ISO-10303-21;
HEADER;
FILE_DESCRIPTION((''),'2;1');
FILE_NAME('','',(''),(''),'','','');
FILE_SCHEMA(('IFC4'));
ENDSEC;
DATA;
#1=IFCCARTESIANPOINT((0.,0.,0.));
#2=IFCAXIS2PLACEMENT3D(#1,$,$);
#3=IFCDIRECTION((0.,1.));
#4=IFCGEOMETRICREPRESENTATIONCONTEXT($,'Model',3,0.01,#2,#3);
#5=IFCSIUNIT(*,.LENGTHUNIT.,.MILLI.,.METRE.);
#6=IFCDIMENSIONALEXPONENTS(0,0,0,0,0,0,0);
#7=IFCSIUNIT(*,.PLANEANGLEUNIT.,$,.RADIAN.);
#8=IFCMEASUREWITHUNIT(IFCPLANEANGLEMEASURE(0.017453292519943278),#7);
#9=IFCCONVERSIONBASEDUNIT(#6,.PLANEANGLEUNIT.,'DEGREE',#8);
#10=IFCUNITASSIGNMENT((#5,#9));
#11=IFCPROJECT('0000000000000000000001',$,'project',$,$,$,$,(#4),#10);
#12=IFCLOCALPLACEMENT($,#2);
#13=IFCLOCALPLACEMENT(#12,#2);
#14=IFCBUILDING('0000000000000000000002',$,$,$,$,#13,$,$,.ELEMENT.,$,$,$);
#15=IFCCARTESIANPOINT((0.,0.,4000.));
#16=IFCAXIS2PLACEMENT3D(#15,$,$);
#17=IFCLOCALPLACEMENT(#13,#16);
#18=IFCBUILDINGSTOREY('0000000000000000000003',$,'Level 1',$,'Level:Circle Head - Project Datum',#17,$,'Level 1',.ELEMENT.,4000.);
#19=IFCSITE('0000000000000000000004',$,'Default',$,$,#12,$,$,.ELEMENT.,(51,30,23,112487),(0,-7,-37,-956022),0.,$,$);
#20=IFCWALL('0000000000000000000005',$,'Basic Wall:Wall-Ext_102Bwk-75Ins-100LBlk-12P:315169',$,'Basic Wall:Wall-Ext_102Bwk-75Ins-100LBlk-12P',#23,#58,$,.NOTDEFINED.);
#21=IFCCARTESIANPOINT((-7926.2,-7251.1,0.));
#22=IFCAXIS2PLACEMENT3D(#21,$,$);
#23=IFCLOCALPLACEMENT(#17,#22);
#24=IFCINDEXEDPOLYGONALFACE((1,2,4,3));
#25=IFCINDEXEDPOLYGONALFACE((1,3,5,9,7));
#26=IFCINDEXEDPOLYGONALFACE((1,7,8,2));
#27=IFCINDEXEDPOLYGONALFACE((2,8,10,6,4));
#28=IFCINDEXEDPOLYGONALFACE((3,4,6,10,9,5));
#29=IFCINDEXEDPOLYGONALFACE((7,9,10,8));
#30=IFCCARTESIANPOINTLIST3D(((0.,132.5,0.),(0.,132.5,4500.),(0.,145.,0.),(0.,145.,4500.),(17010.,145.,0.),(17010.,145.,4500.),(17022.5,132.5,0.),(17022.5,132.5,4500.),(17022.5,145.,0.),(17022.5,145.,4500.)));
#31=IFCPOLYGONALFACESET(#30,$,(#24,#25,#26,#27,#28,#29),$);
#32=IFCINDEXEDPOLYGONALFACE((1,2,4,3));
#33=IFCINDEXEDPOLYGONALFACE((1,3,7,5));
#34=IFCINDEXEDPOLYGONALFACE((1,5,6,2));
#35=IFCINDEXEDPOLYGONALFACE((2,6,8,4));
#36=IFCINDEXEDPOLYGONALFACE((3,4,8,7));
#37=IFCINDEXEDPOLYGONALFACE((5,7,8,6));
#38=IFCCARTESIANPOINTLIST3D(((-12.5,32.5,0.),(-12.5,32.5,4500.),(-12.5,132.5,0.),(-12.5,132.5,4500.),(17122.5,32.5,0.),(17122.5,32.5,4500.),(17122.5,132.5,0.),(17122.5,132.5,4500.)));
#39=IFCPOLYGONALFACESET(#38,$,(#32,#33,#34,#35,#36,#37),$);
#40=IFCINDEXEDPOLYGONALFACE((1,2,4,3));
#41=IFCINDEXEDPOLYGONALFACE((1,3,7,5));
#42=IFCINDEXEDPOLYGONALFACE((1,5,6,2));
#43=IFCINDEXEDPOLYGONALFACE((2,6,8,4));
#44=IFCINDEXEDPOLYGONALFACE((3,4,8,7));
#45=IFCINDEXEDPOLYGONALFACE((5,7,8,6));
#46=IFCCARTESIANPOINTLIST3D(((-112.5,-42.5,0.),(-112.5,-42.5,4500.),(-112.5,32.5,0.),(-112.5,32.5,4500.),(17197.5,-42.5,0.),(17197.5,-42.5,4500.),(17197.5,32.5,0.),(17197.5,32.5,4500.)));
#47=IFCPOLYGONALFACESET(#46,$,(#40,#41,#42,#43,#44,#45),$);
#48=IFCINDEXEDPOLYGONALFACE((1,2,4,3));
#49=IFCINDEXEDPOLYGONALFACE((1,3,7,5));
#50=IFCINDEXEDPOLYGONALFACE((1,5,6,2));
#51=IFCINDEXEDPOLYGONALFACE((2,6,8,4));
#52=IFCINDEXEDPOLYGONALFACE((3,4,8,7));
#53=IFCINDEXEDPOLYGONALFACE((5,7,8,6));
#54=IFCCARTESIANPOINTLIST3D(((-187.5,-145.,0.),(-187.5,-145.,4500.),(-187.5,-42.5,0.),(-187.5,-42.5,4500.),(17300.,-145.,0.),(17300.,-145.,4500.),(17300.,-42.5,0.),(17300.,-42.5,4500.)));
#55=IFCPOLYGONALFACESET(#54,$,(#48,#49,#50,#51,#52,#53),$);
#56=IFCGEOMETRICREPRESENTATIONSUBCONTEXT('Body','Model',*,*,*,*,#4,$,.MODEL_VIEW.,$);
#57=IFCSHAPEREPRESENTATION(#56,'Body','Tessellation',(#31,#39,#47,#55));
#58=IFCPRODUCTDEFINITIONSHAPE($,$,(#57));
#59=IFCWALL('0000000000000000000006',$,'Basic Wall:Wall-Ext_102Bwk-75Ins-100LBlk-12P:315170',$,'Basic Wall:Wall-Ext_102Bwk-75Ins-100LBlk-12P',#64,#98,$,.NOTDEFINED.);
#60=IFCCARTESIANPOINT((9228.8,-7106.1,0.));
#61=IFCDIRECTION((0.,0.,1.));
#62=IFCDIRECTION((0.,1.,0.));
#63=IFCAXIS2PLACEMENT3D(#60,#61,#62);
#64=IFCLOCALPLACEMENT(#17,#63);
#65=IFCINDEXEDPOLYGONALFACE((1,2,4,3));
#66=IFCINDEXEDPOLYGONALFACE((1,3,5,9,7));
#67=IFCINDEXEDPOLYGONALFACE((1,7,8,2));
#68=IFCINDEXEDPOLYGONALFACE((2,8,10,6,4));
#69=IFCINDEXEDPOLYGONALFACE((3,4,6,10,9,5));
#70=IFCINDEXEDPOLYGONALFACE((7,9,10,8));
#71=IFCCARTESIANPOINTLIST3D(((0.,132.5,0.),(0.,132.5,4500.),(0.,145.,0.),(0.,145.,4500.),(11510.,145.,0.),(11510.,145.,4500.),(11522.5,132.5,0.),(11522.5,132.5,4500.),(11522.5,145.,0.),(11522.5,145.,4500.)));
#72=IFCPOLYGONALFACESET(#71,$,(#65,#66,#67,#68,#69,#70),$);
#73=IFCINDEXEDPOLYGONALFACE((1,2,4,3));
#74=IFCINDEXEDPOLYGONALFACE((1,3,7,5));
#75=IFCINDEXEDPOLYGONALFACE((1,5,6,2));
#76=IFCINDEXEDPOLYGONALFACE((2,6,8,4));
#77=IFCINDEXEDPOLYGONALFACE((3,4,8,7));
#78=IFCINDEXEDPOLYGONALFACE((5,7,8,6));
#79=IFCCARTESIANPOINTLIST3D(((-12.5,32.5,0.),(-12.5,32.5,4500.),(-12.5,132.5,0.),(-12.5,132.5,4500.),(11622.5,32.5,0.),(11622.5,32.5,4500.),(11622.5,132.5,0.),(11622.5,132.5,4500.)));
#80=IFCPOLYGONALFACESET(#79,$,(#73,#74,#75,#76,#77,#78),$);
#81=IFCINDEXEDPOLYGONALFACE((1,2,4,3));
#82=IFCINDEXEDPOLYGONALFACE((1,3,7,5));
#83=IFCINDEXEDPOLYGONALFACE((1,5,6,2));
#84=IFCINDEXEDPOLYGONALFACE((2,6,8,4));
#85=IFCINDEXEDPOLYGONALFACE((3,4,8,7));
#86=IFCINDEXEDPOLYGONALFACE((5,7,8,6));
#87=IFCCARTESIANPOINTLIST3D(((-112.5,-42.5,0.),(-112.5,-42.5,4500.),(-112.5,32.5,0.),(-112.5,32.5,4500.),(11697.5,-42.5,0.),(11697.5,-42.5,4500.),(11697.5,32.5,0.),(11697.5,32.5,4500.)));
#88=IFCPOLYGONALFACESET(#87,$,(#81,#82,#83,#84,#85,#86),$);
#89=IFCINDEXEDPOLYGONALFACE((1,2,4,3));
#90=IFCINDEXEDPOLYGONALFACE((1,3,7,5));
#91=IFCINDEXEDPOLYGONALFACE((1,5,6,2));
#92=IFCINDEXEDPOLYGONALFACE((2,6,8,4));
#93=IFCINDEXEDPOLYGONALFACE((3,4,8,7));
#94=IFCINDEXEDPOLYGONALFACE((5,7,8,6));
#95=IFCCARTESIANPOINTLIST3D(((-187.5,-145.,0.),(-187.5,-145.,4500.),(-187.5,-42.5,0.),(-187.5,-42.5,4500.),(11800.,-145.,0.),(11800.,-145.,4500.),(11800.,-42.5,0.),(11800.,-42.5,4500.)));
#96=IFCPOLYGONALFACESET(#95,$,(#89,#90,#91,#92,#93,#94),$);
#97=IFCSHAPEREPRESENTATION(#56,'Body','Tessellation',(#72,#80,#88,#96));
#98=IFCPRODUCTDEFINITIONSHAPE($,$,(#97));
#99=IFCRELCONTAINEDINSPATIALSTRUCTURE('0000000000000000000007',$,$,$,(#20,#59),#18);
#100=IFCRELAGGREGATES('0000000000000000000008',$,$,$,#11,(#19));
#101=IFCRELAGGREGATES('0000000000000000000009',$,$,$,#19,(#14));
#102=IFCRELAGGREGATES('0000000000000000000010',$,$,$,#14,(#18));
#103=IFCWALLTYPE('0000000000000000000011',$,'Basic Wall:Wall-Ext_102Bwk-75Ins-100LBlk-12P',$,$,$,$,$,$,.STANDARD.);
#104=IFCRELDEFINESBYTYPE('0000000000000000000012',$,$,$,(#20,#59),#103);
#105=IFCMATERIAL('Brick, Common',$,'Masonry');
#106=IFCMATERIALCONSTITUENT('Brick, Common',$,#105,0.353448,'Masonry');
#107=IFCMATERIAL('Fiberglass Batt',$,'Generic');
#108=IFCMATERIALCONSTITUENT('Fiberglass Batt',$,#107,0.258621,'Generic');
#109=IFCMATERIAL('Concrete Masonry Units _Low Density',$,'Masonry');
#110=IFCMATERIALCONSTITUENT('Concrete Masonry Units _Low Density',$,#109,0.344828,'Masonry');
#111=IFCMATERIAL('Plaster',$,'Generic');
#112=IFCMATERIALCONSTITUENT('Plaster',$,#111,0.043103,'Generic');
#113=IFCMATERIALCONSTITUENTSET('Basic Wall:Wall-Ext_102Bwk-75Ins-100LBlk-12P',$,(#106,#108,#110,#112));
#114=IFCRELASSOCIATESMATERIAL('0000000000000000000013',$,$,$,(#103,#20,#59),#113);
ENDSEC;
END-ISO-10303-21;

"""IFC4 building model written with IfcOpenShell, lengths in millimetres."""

from ifc_helpers import new_model, entity, si_unit, converted_unit, direction, frame, origin, place, context, subcontext, project, spatial, indexed_curve, outline, extrude, material, constituent, constituent_set, type_object, element, save


model = new_model("IFC4")

# Units and contexts
model_context = context("Model", 3, precision=0.01, world=origin(), true_north=direction((0.0, 1.0)))
body_context = subcontext(model_context, "Body", "Model", "MODEL_VIEW")
ifc_project = project(units=[si_unit("LENGTHUNIT", "METRE", prefix="MILLI"), converted_unit("PLANEANGLEUNIT", "DEGREE", entity("IfcPlaneAngleMeasure", 0.017453292519943278), si_unit("PLANEANGLEUNIT", "RADIAN"), dimensions=[0, 0, 0, 0, 0, 0, 0])], contexts=[model_context])

# Site, building, storey
site_placement = place(None, origin())
site = spatial("IfcSite", under=ifc_project, at=site_placement, Name="Default", CompositionType="ELEMENT", RefLatitude=(51, 30, 23, 112487), RefLongitude=(0, -7, -37, -956022), RefElevation=0.0)
building_placement = place(site_placement, origin())
building = spatial("IfcBuilding", under=site, at=building_placement, CompositionType="ELEMENT")
storey_placement = place(building_placement, frame((0.0, 0.0, 4000.0)))
storey = spatial("IfcBuildingStorey", under=building, at=storey_placement, Name="Level 1", ObjectType="Level:Circle Head - Project Datum", LongName="Level 1", CompositionType="ELEMENT", Elevation=4000.0)

# Shared definitions
ifc_material_1 = material(Name="Plaster", Category="Generic")

# Walls
ifc_material_2 = material(Name="Brick, Common", Category="Masonry")
ifc_constituent_1 = constituent(ifc_material_2, Name="Brick, Common", Category="Masonry", fraction=0.353448)
ifc_material_3 = material(Name="Fiberglass Batt", Category="Generic")
ifc_constituent_2 = constituent(ifc_material_3, Name="Fiberglass Batt", Category="Generic", fraction=0.258621)
ifc_material_4 = material(Name="Concrete Masonry Units _Low Density", Category="Masonry")
ifc_constituent_3 = constituent(ifc_material_4, Name="Concrete Masonry Units _Low Density", Category="Masonry", fraction=0.344828)
ifc_constituent_4 = constituent(ifc_material_1, Name="Plaster", Category="Generic", fraction=0.043103)
ifc_constituent_set_1 = constituent_set(constituents=[ifc_constituent_1, ifc_constituent_2, ifc_constituent_3, ifc_constituent_4], Name="Basic Wall:Wall-Ext_102Bwk-75Ins-100LBlk-12P")
wall_type_1 = type_object("IfcWallType", Name="Basic Wall:Wall-Ext_102Bwk-75Ins-100LBlk-12P", PredefinedType="STANDARD", material=ifc_constituent_set_1)
wall_1_placement = place(storey_placement, frame((-7926.2, -7251.1, 0.0)))
element("IfcWall", 1, at=wall_1_placement, inside=storey, type_object=wall_type_1, material=ifc_constituent_set_1, Name="Basic Wall:Wall-Ext_102Bwk-75Ins-100LBlk-12P:315169", ObjectType="Basic Wall:Wall-Ext_102Bwk-75Ins-100LBlk-12P", PredefinedType="NOTDEFINED", context=body_context, shape_type="SweptSolid", body=[
    extrude(outline(indexed_curve([(-6799.0, -5.0), (10211.0, -5.0), (10211.0, 7.5), (-6811.5, 7.5), (-6811.5, -5.0), (-6799.0, -5.0)], self_intersect=False)), frame((10211.0, 140.0, 0.0), z_axis=(0.0, 0.0, 1.0), x_axis=(-1.0, 0.0, 0.0)), (0.0, 0.0, 1.0), 4500.0),
    extrude(outline(indexed_curve([(-8567.5, -50.0), (8567.5, -50.0), (8567.5, 50.0), (-8567.5, 50.0), (-8567.5, -50.0)], self_intersect=False)), frame((8555.0, 82.5, 0.0)), (0.0, 0.0, 1.0), 4500.0),
    extrude(outline(indexed_curve([(-8655.0, -37.5), (8655.0, -37.5), (8655.0, 37.5), (-8655.0, 37.5), (-8655.0, -37.5)], self_intersect=False)), frame((8542.5, -5.0, 0.0)), (0.0, 0.0, 1.0), 4500.0),
    extrude(outline(indexed_curve([(-51.3, -8743.8), (51.3, -8743.8), (51.3, 8743.8), (-51.3, 8743.8), (-51.3, -8743.8)], self_intersect=False)), frame((8556.2, -93.8, 0.0), z_axis=(0.0, 0.0, 1.0), x_axis=(0.0, 1.0, 0.0)), (0.0, 0.0, 1.0), 4500.0),
])
wall_2_placement = place(storey_placement, frame((9228.8, -7106.1, 0.0), z_axis=(0.0, 0.0, 1.0), x_axis=(0.0, 1.0, 0.0)))
element("IfcWall", 2, at=wall_2_placement, inside=storey, type_object=wall_type_1, material=ifc_constituent_set_1, Name="Basic Wall:Wall-Ext_102Bwk-75Ins-100LBlk-12P:315170", ObjectType="Basic Wall:Wall-Ext_102Bwk-75Ins-100LBlk-12P", PredefinedType="NOTDEFINED", context=body_context, shape_type="SweptSolid", body=[
    extrude(outline(indexed_curve([(-4599.0, -5.0), (6911.0, -5.0), (6911.0, 7.5), (-4611.5, 7.5), (-4611.5, -5.0), (-4599.0, -5.0)], self_intersect=False)), frame((6911.0, 140.0, 0.0), z_axis=(0.0, 0.0, 1.0), x_axis=(-1.0, 0.0, 0.0)), (0.0, 0.0, 1.0), 4500.0),
    extrude(outline(indexed_curve([(-5817.5, -50.0), (5817.5, -50.0), (5817.5, 50.0), (-5817.5, 50.0), (-5817.5, -50.0)], self_intersect=False)), frame((5805.0, 82.5, 0.0)), (0.0, 0.0, 1.0), 4500.0),
    extrude(outline(indexed_curve([(-5905.0, -37.5), (5905.0, -37.5), (5905.0, 37.5), (-5905.0, 37.5), (-5905.0, -37.5)], self_intersect=False)), frame((5792.5, -5.0, 0.0)), (0.0, 0.0, 1.0), 4500.0),
    extrude(outline(indexed_curve([(-51.3, -5993.7), (51.2, -5993.7), (51.3, 5993.7), (-51.2, 5993.7), (-51.3, -5993.7)], self_intersect=False)), frame((5806.2, -93.8, 0.0), z_axis=(0.0, 0.0, 1.0), x_axis=(0.0, 1.0, 0.0)), (0.0, 0.0, 1.0), 4500.0),
])

save(model, "model.ifc")
